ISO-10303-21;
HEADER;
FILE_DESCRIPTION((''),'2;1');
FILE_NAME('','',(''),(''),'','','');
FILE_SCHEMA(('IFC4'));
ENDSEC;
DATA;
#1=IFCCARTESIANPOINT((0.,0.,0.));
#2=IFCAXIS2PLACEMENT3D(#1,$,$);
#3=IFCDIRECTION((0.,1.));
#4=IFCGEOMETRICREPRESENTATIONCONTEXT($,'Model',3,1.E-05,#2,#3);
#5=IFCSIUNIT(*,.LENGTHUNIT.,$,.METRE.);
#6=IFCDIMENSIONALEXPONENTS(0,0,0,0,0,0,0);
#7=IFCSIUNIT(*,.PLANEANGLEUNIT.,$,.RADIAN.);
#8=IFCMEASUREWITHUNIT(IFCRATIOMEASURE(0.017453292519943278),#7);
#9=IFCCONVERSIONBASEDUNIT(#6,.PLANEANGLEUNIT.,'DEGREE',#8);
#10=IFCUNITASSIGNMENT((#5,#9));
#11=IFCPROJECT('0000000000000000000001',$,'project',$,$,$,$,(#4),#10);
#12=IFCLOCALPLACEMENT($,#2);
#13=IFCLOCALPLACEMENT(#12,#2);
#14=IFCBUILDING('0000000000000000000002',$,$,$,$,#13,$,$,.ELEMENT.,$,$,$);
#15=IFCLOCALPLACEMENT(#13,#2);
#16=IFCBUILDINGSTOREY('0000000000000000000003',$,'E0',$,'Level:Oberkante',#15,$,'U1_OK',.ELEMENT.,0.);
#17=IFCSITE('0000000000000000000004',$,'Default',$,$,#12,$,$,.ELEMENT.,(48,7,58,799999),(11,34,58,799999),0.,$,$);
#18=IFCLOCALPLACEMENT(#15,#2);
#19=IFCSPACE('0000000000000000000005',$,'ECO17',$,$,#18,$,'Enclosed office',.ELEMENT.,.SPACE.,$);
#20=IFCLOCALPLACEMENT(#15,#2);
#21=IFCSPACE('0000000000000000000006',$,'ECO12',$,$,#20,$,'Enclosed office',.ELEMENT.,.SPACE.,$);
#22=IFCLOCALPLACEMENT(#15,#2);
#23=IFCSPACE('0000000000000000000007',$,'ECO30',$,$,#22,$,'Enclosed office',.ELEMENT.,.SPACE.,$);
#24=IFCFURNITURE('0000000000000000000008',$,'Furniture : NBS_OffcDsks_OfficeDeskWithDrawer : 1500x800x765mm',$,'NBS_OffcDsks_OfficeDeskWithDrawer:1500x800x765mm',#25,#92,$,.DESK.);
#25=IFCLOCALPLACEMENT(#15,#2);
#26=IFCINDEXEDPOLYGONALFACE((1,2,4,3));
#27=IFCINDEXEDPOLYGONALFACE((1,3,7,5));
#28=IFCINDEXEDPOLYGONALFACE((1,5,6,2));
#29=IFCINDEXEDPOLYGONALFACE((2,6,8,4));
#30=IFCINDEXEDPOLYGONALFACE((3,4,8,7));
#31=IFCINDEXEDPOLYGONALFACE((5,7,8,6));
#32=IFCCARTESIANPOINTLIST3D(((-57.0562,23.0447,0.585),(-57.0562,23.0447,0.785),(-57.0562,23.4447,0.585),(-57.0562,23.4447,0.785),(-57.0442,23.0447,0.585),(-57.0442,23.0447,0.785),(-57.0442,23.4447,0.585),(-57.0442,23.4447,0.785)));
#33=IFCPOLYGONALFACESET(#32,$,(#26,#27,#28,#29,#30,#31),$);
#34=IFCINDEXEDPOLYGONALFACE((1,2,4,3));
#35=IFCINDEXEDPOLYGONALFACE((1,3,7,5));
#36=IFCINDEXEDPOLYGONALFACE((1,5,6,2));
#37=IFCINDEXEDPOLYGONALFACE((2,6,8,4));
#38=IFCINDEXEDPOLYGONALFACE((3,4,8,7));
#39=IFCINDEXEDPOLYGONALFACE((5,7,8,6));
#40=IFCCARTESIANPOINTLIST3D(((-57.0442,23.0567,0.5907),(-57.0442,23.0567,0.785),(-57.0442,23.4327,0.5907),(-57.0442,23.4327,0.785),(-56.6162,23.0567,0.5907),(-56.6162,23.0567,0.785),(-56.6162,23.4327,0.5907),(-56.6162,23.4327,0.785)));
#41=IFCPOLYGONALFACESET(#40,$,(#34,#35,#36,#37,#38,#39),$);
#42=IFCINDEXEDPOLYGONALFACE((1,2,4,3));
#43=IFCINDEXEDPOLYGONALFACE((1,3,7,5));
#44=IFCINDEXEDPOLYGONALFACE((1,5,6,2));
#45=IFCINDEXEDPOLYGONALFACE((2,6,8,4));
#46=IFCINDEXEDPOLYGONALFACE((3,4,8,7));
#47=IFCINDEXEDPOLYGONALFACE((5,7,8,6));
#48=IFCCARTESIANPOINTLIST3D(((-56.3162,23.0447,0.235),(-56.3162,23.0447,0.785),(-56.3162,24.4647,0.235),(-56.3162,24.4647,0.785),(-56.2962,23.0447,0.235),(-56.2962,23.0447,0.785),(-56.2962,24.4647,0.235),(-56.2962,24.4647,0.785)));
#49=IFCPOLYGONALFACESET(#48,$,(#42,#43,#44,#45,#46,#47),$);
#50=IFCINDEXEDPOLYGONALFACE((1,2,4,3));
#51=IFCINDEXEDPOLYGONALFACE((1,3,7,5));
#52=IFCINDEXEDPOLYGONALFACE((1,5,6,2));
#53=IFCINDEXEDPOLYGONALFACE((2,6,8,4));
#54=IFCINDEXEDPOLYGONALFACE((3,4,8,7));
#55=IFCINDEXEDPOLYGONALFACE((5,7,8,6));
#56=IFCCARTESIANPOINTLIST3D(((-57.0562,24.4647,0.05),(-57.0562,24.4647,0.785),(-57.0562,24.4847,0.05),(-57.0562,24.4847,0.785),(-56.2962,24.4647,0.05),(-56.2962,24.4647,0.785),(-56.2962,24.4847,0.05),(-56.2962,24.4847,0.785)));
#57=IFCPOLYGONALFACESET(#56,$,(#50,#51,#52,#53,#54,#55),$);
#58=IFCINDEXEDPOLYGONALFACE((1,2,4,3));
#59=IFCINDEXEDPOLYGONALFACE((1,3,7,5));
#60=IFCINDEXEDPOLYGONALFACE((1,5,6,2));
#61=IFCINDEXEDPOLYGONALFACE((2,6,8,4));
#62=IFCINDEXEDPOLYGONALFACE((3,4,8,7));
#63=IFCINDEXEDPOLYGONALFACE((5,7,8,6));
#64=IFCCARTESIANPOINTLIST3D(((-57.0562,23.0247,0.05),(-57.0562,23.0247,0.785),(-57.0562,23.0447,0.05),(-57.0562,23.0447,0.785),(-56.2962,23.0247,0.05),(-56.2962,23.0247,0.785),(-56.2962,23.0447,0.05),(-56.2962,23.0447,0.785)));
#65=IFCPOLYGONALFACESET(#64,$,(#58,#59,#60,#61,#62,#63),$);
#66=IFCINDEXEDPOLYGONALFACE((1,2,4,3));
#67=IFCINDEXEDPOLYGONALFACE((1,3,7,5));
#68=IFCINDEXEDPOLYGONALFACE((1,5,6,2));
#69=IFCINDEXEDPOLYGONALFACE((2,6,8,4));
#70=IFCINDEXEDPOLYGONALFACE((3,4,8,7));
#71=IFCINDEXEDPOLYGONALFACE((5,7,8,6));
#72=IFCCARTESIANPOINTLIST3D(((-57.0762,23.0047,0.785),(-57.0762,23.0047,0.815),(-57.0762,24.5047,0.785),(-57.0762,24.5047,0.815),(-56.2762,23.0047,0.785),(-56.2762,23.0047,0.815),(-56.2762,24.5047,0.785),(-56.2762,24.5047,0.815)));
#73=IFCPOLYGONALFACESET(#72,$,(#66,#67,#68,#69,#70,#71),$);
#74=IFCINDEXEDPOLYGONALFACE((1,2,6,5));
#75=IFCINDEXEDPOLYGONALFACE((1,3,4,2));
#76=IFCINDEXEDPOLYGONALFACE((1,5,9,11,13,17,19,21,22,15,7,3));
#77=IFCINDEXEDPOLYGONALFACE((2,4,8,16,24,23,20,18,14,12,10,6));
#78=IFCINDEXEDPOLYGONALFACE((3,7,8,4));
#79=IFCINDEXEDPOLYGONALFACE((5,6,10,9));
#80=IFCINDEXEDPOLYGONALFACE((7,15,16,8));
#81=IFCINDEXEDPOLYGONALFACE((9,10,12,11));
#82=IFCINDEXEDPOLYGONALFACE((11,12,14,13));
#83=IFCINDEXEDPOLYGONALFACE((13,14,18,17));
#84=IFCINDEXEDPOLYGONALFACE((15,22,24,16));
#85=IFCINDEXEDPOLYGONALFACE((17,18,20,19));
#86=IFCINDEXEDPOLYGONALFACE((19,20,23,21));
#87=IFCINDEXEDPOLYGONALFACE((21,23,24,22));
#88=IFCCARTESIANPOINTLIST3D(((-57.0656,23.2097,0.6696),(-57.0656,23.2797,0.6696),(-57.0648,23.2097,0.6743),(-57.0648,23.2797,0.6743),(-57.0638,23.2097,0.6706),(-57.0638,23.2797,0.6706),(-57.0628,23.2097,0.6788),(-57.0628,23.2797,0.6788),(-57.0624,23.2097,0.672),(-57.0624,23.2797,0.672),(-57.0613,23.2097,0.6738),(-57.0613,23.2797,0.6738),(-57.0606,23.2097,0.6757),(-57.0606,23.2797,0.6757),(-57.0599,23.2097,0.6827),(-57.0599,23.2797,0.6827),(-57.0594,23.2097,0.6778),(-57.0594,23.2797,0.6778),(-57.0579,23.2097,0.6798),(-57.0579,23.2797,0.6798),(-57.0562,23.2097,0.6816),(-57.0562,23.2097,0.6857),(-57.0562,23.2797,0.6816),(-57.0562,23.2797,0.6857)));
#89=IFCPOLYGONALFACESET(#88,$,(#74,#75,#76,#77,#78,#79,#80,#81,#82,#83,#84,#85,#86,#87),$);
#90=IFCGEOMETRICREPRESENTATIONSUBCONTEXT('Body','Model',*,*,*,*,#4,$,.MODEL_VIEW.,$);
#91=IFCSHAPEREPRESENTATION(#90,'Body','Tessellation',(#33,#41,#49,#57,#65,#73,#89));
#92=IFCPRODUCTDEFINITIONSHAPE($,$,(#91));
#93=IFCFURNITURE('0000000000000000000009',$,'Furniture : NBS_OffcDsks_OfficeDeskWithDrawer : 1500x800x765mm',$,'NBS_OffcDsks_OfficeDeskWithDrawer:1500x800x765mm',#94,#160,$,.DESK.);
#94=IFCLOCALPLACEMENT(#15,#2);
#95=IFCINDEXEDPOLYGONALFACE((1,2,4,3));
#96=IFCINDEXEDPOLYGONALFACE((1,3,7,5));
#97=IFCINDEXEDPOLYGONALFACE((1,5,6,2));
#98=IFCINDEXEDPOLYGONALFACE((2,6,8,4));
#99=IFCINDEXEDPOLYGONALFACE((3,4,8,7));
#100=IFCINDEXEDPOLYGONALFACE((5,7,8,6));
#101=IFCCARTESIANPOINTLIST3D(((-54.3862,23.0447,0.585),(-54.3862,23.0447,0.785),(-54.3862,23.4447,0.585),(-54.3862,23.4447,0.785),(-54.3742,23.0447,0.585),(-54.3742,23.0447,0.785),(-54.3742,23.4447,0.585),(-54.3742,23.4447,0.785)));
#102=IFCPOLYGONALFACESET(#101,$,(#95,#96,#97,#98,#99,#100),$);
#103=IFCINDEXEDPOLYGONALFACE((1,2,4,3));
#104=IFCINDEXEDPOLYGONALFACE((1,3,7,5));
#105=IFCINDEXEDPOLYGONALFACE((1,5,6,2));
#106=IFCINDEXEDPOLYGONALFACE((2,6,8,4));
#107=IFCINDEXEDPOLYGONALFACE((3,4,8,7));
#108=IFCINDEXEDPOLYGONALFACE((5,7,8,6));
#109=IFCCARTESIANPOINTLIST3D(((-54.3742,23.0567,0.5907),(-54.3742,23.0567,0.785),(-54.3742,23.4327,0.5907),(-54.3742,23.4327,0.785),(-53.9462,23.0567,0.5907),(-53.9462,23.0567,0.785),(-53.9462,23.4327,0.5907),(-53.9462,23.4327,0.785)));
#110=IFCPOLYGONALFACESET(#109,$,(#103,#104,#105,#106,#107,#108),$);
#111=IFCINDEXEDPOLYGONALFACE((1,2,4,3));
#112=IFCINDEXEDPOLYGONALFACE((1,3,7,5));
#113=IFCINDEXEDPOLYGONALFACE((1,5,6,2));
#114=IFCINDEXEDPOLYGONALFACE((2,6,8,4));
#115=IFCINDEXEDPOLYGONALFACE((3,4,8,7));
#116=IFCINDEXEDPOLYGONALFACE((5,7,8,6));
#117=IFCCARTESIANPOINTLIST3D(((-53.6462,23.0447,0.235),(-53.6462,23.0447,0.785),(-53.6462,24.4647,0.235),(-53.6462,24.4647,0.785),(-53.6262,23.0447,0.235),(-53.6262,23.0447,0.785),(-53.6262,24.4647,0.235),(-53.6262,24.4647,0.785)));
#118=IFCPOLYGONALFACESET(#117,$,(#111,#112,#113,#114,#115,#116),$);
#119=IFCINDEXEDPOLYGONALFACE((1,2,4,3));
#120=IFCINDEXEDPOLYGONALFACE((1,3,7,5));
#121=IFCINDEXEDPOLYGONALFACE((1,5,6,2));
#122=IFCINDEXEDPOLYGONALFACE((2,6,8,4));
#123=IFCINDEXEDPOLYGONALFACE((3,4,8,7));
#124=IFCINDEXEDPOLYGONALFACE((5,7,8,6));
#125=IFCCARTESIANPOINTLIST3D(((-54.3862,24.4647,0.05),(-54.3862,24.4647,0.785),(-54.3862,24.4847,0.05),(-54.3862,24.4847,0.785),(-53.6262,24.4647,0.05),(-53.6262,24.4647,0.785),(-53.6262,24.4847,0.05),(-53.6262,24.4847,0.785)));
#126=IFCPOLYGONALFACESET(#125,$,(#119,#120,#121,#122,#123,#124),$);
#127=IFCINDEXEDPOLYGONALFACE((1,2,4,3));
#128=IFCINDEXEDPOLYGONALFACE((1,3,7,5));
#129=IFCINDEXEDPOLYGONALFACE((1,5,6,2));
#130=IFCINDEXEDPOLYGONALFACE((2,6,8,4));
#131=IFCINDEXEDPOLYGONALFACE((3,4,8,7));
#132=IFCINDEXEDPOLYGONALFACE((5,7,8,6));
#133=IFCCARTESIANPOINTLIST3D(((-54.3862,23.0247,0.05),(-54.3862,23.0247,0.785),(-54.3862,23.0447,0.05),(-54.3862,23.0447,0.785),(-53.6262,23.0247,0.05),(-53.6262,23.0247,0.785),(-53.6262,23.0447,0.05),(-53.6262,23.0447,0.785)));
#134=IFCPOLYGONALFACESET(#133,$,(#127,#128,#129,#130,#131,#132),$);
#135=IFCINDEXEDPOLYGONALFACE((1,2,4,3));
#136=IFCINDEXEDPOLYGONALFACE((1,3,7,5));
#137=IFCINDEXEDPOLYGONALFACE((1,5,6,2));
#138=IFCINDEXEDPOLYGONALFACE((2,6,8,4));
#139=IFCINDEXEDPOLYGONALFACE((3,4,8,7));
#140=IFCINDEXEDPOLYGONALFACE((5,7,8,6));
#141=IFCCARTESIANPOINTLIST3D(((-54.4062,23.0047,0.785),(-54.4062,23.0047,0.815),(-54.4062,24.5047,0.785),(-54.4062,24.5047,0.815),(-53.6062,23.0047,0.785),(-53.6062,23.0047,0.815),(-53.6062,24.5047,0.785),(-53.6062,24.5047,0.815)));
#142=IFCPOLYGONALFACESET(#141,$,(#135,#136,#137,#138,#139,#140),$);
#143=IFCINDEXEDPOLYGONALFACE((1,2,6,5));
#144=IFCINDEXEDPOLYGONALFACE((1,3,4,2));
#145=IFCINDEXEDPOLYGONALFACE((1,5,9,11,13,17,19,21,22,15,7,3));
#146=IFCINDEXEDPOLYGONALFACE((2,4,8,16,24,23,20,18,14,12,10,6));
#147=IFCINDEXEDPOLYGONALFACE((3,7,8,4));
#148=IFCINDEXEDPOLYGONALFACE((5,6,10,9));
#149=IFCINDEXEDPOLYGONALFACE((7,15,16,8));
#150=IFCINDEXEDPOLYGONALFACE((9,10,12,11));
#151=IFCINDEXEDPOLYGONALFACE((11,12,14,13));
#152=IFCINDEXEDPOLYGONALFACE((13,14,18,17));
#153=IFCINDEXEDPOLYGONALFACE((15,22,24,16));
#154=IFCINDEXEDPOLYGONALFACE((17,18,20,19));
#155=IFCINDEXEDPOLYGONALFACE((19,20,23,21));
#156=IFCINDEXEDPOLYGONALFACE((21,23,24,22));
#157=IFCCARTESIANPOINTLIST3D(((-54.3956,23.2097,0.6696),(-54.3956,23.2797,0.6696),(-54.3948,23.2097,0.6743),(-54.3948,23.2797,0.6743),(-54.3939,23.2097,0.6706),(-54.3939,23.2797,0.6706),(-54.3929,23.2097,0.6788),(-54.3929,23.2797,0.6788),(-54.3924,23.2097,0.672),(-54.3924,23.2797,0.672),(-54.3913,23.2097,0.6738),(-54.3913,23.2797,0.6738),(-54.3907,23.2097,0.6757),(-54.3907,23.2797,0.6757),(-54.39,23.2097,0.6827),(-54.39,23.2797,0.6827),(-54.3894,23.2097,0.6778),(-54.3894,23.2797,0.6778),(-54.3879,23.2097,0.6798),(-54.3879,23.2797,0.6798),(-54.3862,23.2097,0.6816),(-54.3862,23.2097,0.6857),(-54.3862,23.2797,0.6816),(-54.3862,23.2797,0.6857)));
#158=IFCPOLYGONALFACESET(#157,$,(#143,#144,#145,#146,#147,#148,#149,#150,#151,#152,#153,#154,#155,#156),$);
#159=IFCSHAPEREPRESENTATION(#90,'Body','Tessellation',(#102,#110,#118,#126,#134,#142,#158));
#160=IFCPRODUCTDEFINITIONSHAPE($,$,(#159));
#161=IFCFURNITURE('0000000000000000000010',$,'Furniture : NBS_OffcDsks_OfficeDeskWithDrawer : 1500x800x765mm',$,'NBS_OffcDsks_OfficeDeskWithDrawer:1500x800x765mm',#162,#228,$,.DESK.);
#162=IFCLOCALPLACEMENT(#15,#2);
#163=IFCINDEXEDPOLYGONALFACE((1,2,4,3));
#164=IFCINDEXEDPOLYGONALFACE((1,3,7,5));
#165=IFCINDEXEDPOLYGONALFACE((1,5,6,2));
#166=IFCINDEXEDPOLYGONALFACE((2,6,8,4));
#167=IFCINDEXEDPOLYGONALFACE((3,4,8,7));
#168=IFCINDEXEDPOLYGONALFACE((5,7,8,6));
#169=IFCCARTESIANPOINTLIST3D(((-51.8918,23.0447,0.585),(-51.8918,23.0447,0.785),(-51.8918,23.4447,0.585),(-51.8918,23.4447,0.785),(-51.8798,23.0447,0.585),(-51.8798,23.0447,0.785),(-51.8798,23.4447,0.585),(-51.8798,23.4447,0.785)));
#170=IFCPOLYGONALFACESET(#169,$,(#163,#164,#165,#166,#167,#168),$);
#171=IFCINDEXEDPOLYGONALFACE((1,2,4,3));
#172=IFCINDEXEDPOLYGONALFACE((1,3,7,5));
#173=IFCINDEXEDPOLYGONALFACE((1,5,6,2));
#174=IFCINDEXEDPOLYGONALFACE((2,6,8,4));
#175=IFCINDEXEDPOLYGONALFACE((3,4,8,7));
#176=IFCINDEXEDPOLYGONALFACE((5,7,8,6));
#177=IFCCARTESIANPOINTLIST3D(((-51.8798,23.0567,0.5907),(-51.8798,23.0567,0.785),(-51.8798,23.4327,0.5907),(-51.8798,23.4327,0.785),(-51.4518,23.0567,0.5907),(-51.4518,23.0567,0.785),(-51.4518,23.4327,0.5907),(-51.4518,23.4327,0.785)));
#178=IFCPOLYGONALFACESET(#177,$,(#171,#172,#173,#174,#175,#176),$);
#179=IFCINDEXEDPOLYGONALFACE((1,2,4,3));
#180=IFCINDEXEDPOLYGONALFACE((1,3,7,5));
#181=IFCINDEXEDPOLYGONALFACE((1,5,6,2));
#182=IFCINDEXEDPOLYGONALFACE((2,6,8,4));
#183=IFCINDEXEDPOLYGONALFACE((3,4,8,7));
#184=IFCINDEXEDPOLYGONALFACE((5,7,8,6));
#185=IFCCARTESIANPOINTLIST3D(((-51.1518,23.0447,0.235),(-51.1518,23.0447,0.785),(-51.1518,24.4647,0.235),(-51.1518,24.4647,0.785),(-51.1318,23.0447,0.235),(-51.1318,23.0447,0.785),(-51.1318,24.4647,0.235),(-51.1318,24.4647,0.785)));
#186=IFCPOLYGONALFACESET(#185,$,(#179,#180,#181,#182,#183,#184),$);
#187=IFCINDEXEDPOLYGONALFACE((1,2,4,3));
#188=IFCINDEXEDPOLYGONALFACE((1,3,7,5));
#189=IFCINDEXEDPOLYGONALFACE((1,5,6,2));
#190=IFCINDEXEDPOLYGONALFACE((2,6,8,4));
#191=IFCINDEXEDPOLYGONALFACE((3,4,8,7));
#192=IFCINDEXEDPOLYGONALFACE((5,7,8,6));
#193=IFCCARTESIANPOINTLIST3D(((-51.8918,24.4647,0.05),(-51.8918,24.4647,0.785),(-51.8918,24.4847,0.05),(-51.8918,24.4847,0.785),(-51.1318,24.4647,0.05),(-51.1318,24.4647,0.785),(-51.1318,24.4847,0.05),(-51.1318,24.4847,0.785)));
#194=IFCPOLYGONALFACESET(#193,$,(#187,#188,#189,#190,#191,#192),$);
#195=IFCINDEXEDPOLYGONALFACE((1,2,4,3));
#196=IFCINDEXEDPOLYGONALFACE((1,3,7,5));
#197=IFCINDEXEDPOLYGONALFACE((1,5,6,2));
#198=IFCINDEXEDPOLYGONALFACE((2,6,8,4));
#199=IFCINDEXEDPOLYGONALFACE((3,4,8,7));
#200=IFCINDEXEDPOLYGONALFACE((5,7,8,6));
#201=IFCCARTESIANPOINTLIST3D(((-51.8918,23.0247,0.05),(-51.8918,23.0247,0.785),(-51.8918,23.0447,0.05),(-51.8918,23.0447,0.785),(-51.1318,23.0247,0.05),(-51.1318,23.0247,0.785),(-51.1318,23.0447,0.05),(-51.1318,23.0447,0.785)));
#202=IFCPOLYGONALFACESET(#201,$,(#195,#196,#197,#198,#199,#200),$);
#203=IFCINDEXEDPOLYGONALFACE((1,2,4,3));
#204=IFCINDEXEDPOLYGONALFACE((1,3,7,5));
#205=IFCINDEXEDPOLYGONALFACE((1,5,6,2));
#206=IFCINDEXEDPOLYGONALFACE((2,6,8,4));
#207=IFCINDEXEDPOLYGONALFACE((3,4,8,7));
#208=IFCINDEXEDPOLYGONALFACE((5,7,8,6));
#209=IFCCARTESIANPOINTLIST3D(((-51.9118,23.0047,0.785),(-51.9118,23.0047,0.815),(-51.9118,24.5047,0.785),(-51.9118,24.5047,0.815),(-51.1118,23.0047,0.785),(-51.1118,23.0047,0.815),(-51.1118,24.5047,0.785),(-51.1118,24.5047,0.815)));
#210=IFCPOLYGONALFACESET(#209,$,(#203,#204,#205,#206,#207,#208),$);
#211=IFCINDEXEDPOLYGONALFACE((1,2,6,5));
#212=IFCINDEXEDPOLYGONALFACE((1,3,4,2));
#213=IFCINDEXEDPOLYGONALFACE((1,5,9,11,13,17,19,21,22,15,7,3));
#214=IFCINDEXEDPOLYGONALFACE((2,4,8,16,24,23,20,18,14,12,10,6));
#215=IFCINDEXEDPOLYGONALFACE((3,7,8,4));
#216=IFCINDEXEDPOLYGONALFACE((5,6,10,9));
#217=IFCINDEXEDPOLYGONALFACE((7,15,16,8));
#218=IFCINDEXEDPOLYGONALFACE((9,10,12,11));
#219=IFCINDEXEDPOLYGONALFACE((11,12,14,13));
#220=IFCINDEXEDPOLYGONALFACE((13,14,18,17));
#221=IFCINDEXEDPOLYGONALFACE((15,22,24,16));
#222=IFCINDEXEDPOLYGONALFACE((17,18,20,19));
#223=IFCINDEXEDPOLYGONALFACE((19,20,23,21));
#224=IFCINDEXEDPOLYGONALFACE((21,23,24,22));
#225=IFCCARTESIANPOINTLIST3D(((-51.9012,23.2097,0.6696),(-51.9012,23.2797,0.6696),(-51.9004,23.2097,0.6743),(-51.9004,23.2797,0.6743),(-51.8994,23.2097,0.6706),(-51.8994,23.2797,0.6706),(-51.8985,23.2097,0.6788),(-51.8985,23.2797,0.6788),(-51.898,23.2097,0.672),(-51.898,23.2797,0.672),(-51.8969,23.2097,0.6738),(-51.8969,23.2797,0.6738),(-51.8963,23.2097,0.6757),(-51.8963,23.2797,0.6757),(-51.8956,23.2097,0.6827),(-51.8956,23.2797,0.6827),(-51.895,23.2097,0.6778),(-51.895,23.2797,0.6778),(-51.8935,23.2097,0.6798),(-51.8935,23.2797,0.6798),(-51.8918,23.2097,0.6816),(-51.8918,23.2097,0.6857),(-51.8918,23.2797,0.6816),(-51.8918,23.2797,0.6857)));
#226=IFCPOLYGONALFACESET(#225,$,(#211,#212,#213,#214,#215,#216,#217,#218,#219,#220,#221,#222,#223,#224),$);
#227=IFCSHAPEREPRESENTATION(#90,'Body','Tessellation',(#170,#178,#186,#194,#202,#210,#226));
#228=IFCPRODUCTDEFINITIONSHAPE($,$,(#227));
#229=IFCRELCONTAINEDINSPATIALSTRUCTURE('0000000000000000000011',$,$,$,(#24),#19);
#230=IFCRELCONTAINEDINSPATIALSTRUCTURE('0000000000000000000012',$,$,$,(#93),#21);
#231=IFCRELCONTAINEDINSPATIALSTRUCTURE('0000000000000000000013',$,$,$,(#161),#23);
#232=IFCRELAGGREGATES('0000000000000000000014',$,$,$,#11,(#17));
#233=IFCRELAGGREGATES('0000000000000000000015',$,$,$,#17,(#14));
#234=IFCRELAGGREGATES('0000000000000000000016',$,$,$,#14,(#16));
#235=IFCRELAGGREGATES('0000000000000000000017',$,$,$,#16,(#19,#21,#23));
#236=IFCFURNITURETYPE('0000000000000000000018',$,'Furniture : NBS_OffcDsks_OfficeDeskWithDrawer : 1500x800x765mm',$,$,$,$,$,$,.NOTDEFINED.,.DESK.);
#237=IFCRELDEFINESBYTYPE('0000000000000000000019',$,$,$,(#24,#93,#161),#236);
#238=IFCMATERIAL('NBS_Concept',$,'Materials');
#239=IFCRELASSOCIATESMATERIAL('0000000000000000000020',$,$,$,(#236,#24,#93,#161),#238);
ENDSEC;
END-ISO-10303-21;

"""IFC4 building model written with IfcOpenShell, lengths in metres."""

from ifc_helpers import new_model, entity, si_unit, converted_unit, direction, frame, origin, place, context, subcontext, project, spatial, line, arc, indexed_curve, outline, extrude, source, transform, mapped, material, type_object, type_shapes, element, save


model = new_model("IFC4")

# Units and contexts
model_context = context("Model", 3, precision=1e-05, world=origin(), true_north=direction((0.0, 1.0)))
body_context = subcontext(model_context, "Body", "Model", "MODEL_VIEW")
ifc_project = project(units=[si_unit("LENGTHUNIT", "METRE"), converted_unit("PLANEANGLEUNIT", "DEGREE", entity("IfcRatioMeasure", 0.017453292519943278), si_unit("PLANEANGLEUNIT", "RADIAN"), dimensions=[0, 0, 0, 0, 0, 0, 0])], contexts=[model_context])

# Site, building, storey
site_placement = place(None, origin())
site = spatial("IfcSite", under=ifc_project, at=site_placement, Name="Default", CompositionType="ELEMENT", RefLatitude=(48, 7, 58, 799999), RefLongitude=(11, 34, 58, 799999), RefElevation=0.0)
building_placement = place(site_placement, origin())
building = spatial("IfcBuilding", under=site, at=building_placement, CompositionType="ELEMENT")
storey_placement = place(building_placement, origin())
storey = spatial("IfcBuildingStorey", under=building, at=storey_placement, Name="E0", ObjectType="Level:Oberkante", LongName="U1_OK", CompositionType="ELEMENT", Elevation=0.0)

# Shared definitions
space_1_placement = place(storey_placement, origin())
space_1 = spatial("IfcSpace", under=storey, at=space_1_placement, Name="ECO17", LongName="Enclosed office", CompositionType="ELEMENT", PredefinedType="SPACE")

# Furniture
ifc_material_1 = material(Name="NBS_Concept", Category="Materials")
furniture_type = type_object("IfcFurnitureType", Name="Furniture : NBS_OffcDsks_OfficeDeskWithDrawer : 1500x800x765mm", AssemblyPlace="NOTDEFINED", PredefinedType="DESK", material=ifc_material_1)
shared_shape = source(origin(), body_context, "Body", "SweptSolid", [
    extrude(outline(indexed_curve([(-0.006, -0.2), (0.006, -0.2), (0.006, 0.2), (-0.006, 0.2), (-0.006, -0.2)], self_intersect=False)), frame((0.51, -0.374, 0.535), z_axis=(0.0, 0.0, 1.0), x_axis=(0.0, 1.0, 0.0)), (0.0, 0.0, 1.0), 0.2),
    extrude(outline(indexed_curve([(-0.188, -0.214), (0.188, -0.214), (0.188, 0.214), (-0.188, 0.214), (-0.188, -0.214)], self_intersect=False)), frame((0.51, -0.154, 0.5407), z_axis=(0.0, 0.0, 1.0), x_axis=(-1.0, 0.0, 0.0)), (0.0, 0.0, 1.0), 0.1943),
    extrude(outline(indexed_curve([(-0.71, -0.01), (0.71, -0.01), (0.71, 0.01), (-0.71, 0.01), (-0.71, -0.01)], self_intersect=False)), frame((0.0, 0.37, 0.185), z_axis=(0.0, 0.0, 1.0), x_axis=(-1.0, 0.0, 0.0)), (0.0, 0.0, 1.0), 0.55),
    extrude(outline(indexed_curve([(-0.01, -0.38), (0.01, -0.38), (0.01, 0.38), (-0.01, 0.38), (-0.01, -0.38)], self_intersect=False)), frame((-0.72, 0.0, 0.0), z_axis=(0.0, 0.0, 1.0), x_axis=(-1.0, 0.0, 0.0)), (0.0, 0.0, 1.0), 0.735),
    extrude(outline(indexed_curve([(-0.01, -0.38), (0.01, -0.38), (0.01, 0.38), (-0.01, 0.38), (-0.01, -0.38)], self_intersect=False)), frame((0.72, 0.0, 0.0), z_axis=(0.0, 0.0, 1.0), x_axis=(-1.0, 0.0, 0.0)), (0.0, 0.0, 1.0), 0.735),
    extrude(outline(indexed_curve([(-0.75, -0.4), (0.75, -0.4), (0.75, 0.4), (-0.75, 0.4), (-0.75, -0.4)], self_intersect=False)), frame((0.0, 0.0, 0.735), z_axis=(0.0, 0.0, 1.0), x_axis=(-1.0, 0.0, 0.0)), (0.0, 0.0, 1.0), 0.03),
    extrude(outline(indexed_curve([(0.0086, -0.0059), (0.0061, -0.0027), (0.0025, -0.001), (-0.0007, 0.0009), (-0.0034, 0.0035), (-0.0076, 0.0035), (-0.0007, -0.0032)], segments=[arc(1, 2, 3), arc(3, 4, 5), line(5, 6), arc(6, 7, 1)], self_intersect=False)), frame((0.475, -0.3835, 0.6281), z_axis=(1.0, 0.0, 0.0), x_axis=(0.0, 0.0, -1.0)), (0.0, 0.0, 1.0), 0.07),
])
type_shapes(furniture_type, [shared_shape])
furniture_1_placement = place(space_1_placement, frame((-56.6762, 23.7547, 0.05), z_axis=(0.0, 0.0, 1.0), x_axis=(0.0, -1.0, 0.0)))
element("IfcFurniture", 1, at=furniture_1_placement, inside=space_1, type_object=furniture_type, material=ifc_material_1, Name="Furniture : NBS_OffcDsks_OfficeDeskWithDrawer : 1500x800x765mm", ObjectType="NBS_OffcDsks_OfficeDeskWithDrawer:1500x800x765mm", PredefinedType="DESK", context=body_context, shape_type="MappedRepresentation", body=[
    mapped(shared_shape, transform((0.0, 0.0, 0.0), scale=1.0)),
])

# Shared definitions
space_2_placement = place(storey_placement, origin())
space_2 = spatial("IfcSpace", under=storey, at=space_2_placement, Name="ECO12", LongName="Enclosed office", CompositionType="ELEMENT", PredefinedType="SPACE")

# Furniture
furniture_2_placement = place(space_2_placement, frame((-54.0062, 23.7547, 0.05), z_axis=(0.0, 0.0, 1.0), x_axis=(0.0, -1.0, 0.0)))
element("IfcFurniture", 2, at=furniture_2_placement, inside=space_2, type_object=furniture_type, material=ifc_material_1, Name="Furniture : NBS_OffcDsks_OfficeDeskWithDrawer : 1500x800x765mm", ObjectType="NBS_OffcDsks_OfficeDeskWithDrawer:1500x800x765mm", PredefinedType="DESK", context=body_context, shape_type="MappedRepresentation", body=[
    mapped(shared_shape, transform((0.0, 0.0, 0.0), scale=1.0)),
])

# Shared definitions
space_3_placement = place(storey_placement, origin())
space_3 = spatial("IfcSpace", under=storey, at=space_3_placement, Name="ECO30", LongName="Enclosed office", CompositionType="ELEMENT", PredefinedType="SPACE")

# Furniture
furniture_3_placement = place(space_3_placement, frame((-51.5118, 23.7547, 0.05), z_axis=(0.0, 0.0, 1.0), x_axis=(0.0, -1.0, 0.0)))
element("IfcFurniture", 3, at=furniture_3_placement, inside=space_3, type_object=furniture_type, material=ifc_material_1, Name="Furniture : NBS_OffcDsks_OfficeDeskWithDrawer : 1500x800x765mm", ObjectType="NBS_OffcDsks_OfficeDeskWithDrawer:1500x800x765mm", PredefinedType="DESK", context=body_context, shape_type="MappedRepresentation", body=[
    mapped(shared_shape, transform((0.0, 0.0, 0.0), scale=1.0)),
])

save(model, "model.ifc")
